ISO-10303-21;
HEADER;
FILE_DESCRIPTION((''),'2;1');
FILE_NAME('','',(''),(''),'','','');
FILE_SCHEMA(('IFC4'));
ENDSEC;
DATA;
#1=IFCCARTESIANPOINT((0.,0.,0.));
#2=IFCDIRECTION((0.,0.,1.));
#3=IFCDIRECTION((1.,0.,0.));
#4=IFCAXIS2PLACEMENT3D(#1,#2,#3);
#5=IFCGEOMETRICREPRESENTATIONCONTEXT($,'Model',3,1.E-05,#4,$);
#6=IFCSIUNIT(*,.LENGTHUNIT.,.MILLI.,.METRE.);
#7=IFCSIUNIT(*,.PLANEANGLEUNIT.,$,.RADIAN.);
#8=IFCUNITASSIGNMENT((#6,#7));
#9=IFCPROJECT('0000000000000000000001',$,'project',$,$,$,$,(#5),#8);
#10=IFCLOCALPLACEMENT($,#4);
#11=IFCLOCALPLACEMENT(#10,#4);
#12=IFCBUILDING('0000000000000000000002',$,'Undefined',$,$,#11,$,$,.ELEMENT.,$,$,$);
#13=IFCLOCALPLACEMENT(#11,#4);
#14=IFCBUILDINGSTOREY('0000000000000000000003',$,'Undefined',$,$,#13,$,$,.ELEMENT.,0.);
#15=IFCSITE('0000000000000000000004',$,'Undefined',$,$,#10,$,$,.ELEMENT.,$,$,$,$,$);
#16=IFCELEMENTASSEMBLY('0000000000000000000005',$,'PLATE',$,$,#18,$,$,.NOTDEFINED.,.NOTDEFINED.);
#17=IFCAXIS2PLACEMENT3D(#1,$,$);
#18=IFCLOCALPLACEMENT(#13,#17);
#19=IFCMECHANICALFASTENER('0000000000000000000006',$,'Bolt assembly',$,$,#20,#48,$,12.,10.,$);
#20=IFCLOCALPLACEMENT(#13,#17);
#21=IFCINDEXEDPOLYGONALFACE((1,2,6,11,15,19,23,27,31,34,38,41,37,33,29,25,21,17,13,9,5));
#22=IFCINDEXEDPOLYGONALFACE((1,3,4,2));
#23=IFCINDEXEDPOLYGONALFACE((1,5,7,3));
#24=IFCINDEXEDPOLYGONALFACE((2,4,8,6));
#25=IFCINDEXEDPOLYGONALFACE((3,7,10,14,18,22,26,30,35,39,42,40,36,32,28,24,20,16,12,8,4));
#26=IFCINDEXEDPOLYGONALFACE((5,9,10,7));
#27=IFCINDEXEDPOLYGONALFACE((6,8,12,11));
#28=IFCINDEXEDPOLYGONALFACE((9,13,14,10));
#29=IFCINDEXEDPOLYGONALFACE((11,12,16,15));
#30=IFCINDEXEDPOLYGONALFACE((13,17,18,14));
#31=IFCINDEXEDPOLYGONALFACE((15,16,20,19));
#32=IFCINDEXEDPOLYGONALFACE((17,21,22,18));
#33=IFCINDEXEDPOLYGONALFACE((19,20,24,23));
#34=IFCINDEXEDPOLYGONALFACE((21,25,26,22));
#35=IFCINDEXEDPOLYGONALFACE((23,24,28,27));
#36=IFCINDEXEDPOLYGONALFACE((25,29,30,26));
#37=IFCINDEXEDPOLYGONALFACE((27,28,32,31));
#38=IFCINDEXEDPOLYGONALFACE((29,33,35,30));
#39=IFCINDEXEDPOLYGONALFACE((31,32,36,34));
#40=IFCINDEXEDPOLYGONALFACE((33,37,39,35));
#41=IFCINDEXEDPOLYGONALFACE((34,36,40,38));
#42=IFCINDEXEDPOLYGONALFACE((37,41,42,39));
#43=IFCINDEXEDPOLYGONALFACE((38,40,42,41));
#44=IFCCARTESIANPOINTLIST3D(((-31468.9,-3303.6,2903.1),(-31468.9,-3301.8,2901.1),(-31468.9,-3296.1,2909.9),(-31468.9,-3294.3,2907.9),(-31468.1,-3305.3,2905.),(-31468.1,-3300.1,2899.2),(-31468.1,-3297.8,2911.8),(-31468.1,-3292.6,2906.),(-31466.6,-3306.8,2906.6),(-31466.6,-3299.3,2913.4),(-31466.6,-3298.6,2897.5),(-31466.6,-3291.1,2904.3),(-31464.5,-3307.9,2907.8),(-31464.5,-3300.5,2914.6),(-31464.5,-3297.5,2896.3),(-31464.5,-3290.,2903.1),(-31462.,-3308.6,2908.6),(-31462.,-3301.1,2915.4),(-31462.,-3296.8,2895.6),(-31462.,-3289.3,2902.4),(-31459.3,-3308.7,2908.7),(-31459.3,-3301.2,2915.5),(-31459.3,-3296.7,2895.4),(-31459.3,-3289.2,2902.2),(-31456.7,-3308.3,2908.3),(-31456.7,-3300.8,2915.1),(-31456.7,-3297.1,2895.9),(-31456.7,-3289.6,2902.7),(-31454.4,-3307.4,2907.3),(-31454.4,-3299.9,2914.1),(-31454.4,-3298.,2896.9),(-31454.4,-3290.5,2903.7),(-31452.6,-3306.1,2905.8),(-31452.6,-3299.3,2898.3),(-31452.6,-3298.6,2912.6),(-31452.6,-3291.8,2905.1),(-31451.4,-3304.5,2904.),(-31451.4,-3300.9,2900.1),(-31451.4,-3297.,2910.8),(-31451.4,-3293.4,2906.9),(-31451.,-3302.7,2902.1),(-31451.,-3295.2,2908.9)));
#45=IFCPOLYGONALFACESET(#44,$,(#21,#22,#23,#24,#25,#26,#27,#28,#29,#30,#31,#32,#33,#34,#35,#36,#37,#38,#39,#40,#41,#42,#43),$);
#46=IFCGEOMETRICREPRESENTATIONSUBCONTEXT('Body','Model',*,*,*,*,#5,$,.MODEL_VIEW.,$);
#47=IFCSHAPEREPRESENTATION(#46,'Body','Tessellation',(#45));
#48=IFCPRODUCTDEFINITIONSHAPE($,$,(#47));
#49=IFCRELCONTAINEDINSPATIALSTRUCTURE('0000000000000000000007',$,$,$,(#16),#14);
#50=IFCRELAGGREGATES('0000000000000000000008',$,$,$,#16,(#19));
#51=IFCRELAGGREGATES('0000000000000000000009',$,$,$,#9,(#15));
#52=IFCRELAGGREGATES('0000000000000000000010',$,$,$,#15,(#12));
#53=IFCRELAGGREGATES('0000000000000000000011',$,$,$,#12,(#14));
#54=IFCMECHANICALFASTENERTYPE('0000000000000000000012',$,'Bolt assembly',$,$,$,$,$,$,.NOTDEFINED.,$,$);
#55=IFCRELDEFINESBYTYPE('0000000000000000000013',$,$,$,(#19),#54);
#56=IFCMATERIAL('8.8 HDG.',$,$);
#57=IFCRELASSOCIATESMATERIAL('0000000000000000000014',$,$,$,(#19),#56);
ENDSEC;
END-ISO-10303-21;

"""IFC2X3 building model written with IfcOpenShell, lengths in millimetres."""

from ifc_helpers import new_model, si_unit, frame, origin_with_axes, origin_2d_with_axis, place, context, subcontext, project, spatial, circle, extrude, source, transform, mapped, material, type_object, element, aggregate, save


model = new_model("IFC2X3")

# Units and contexts
model_context = context("Model", 3, precision=1e-05, world=origin_with_axes())
body_context = subcontext(model_context, "Body", "Model", "MODEL_VIEW")
ifc_project = project(units=[si_unit("LENGTHUNIT", "METRE", prefix="MILLI"), si_unit("PLANEANGLEUNIT", "RADIAN")], contexts=[model_context])

# Site, building, storey
site_placement = place(None, origin_with_axes())
site = spatial("IfcSite", under=ifc_project, at=site_placement, Name="Undefined", CompositionType="ELEMENT")
building_placement = place(site_placement, origin_with_axes())
building = spatial("IfcBuilding", under=site, at=building_placement, Name="Undefined", CompositionType="ELEMENT")
storey_placement = place(building_placement, origin_with_axes())
storey = spatial("IfcBuildingStorey", under=building, at=storey_placement, Name="Undefined", CompositionType="ELEMENT", Elevation=0.0)

# Element assembly
assembly_1_placement = place(storey_placement, origin_with_axes())
assembly_1 = element("IfcElementAssembly", 1, at=assembly_1_placement, inside=storey, Name="PLATE", AssemblyPlace="NOTDEFINED", PredefinedType="NOTDEFINED")

# Shared definitions
mechanical_fastener_type = type_object("IfcMechanicalFastenerType", Name="Bolt assembly")

# Mechanical fastener
ifc_material_1 = material(Name="8.8 HDG.")
shared_shape_1 = source(origin_with_axes(), body_context, "Body", "SweptSolid", [
    extrude(circle(Radius=9.0, at=origin_2d_with_axis()), frame((0.0, 0.5, 0.0), z_axis=(0.0, 1.0, 0.0), x_axis=(1.0, 0.0, 0.0)), (0.0, 0.0, 1.0), 10.1),
])
mechanical_fastener_1_placement = place(assembly_1_placement, frame((-31460.0, -3303.1, 2901.7), z_axis=(0.000001, -0.672118, 0.740444), x_axis=(1.0, 0.000001, -0.000001)))
mechanical_fastener_1 = element("IfcMechanicalFastener", 2, at=mechanical_fastener_1_placement, type_object=mechanical_fastener_type, material=ifc_material_1, Name="Bolt assembly", NominalDiameter=12.0, NominalLength=10.0, context=body_context, shape_type="MappedRepresentation", body=[
    mapped(shared_shape_1, transform((0.0, 0.0, 0.0))),
])
aggregate(assembly_1, [mechanical_fastener_1])

save(model, "model.ifc")
